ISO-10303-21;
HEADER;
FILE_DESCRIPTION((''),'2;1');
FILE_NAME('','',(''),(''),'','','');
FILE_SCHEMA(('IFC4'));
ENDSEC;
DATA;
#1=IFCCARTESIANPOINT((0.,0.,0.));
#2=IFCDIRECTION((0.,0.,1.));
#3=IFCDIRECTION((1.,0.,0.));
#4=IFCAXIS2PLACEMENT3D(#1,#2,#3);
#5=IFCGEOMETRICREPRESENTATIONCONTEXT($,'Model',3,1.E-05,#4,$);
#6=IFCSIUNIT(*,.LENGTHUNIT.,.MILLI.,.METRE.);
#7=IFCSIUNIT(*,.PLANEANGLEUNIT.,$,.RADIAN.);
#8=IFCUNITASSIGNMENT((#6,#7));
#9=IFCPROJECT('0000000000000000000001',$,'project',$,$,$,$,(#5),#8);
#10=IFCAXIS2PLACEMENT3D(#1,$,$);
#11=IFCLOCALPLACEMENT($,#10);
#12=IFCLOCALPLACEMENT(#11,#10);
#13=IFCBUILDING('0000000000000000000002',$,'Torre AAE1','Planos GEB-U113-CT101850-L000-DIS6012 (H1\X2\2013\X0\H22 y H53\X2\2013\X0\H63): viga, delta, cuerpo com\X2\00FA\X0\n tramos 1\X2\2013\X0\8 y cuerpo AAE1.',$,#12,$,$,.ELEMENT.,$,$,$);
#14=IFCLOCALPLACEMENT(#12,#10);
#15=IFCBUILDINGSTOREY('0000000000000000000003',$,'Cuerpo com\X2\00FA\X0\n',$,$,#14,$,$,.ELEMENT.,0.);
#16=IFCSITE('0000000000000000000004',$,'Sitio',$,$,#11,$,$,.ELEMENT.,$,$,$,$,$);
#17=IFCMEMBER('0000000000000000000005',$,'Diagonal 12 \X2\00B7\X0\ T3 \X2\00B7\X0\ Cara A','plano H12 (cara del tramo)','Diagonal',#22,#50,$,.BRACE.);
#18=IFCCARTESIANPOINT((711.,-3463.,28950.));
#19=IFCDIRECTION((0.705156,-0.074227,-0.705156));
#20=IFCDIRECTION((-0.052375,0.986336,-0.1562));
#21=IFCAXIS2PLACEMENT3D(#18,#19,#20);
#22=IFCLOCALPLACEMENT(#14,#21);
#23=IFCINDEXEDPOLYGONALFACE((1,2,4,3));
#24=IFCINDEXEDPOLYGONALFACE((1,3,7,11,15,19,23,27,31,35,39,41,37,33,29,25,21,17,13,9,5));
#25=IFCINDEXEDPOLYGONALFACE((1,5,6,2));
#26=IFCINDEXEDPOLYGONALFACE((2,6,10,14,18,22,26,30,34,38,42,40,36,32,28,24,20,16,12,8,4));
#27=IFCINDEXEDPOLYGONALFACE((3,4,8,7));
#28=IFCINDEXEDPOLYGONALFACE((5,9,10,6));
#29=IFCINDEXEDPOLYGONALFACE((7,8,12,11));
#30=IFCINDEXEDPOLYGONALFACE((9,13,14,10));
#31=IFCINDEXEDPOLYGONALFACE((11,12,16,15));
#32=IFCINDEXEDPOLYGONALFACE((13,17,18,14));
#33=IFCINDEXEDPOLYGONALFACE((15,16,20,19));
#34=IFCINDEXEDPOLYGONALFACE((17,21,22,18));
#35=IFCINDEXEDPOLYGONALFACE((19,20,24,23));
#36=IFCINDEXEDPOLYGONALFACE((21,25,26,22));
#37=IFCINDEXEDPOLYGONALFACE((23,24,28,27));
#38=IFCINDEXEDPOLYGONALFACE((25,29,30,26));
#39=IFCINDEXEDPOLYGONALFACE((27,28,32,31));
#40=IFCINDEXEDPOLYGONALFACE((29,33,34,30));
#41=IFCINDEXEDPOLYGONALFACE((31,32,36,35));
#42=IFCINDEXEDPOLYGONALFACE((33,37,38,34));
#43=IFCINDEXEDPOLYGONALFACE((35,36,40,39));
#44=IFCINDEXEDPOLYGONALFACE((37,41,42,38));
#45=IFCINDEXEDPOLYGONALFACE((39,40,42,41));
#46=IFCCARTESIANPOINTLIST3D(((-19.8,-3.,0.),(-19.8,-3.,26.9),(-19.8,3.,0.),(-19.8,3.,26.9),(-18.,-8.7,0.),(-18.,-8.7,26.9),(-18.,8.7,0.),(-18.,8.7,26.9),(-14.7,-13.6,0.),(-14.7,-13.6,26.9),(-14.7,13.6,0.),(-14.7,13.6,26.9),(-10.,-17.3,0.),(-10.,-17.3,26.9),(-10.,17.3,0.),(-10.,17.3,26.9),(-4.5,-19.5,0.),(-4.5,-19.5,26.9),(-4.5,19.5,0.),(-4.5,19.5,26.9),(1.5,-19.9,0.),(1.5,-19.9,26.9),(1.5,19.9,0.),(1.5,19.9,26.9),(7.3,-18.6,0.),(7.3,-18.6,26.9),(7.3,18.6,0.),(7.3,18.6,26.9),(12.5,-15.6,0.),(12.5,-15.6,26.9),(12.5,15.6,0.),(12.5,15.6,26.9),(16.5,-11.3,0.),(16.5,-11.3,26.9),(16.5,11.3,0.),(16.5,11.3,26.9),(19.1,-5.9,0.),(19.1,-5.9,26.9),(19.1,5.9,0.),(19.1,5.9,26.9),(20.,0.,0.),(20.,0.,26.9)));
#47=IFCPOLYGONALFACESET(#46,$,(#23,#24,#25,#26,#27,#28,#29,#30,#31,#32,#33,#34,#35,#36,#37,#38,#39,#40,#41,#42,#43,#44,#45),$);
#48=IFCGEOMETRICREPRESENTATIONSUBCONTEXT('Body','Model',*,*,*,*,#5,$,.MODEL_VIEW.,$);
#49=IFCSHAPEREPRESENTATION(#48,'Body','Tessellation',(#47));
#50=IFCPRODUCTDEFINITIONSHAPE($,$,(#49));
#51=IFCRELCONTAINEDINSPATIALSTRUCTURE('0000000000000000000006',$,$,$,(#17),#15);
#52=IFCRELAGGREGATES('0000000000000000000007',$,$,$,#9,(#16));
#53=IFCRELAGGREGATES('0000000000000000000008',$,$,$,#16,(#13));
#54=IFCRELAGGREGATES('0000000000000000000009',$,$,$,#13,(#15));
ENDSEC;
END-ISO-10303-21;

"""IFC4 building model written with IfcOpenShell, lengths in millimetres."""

from ifc_helpers import new_model, si_unit, frame, origin, origin_with_axes, place, context, subcontext, project, spatial, circle, extrude, element, save


model = new_model("IFC4")

# Units and contexts
model_context = context("Model", 3, precision=1e-05, world=origin_with_axes())
body_context = subcontext(model_context, "Body", "Model", "MODEL_VIEW")
ifc_project = project(units=[si_unit("LENGTHUNIT", "METRE", prefix="MILLI"), si_unit("PLANEANGLEUNIT", "RADIAN")], contexts=[model_context])

# Site, building, storey
site_placement = place(None, origin())
site = spatial("IfcSite", under=ifc_project, at=site_placement, Name="Sitio", CompositionType="ELEMENT")
building_placement = place(site_placement, origin())
building = spatial("IfcBuilding", under=site, at=building_placement, Name="Torre AAE1", Description="Planos GEB-U113-CT101850-L000-DIS6012 (H1–H22 y H53–H63): viga, delta, cuerpo común tramos 1–8 y cuerpo AAE1.", CompositionType="ELEMENT")
storey_placement = place(building_placement, origin())
storey = spatial("IfcBuildingStorey", under=building, at=storey_placement, Name="Cuerpo común", CompositionType="ELEMENT", Elevation=0.0)

# Member
member_1_placement = place(storey_placement, frame((711.0, -3463.0, 28950.0), z_axis=(0.705156, -0.074227, -0.705156), x_axis=(-0.052375, 0.986336, -0.1562)))
element("IfcMember", 1, at=member_1_placement, inside=storey, Name="Diagonal 12 · T3 · Cara A", Description="plano H12 (cara del tramo)", ObjectType="Diagonal", PredefinedType="BRACE", context=body_context, shape_type="SweptSolid", body=[
    extrude(circle(Radius=20.0), None, (0.0, 0.0, 1.0), 26.9),
])

save(model, "model.ifc")
